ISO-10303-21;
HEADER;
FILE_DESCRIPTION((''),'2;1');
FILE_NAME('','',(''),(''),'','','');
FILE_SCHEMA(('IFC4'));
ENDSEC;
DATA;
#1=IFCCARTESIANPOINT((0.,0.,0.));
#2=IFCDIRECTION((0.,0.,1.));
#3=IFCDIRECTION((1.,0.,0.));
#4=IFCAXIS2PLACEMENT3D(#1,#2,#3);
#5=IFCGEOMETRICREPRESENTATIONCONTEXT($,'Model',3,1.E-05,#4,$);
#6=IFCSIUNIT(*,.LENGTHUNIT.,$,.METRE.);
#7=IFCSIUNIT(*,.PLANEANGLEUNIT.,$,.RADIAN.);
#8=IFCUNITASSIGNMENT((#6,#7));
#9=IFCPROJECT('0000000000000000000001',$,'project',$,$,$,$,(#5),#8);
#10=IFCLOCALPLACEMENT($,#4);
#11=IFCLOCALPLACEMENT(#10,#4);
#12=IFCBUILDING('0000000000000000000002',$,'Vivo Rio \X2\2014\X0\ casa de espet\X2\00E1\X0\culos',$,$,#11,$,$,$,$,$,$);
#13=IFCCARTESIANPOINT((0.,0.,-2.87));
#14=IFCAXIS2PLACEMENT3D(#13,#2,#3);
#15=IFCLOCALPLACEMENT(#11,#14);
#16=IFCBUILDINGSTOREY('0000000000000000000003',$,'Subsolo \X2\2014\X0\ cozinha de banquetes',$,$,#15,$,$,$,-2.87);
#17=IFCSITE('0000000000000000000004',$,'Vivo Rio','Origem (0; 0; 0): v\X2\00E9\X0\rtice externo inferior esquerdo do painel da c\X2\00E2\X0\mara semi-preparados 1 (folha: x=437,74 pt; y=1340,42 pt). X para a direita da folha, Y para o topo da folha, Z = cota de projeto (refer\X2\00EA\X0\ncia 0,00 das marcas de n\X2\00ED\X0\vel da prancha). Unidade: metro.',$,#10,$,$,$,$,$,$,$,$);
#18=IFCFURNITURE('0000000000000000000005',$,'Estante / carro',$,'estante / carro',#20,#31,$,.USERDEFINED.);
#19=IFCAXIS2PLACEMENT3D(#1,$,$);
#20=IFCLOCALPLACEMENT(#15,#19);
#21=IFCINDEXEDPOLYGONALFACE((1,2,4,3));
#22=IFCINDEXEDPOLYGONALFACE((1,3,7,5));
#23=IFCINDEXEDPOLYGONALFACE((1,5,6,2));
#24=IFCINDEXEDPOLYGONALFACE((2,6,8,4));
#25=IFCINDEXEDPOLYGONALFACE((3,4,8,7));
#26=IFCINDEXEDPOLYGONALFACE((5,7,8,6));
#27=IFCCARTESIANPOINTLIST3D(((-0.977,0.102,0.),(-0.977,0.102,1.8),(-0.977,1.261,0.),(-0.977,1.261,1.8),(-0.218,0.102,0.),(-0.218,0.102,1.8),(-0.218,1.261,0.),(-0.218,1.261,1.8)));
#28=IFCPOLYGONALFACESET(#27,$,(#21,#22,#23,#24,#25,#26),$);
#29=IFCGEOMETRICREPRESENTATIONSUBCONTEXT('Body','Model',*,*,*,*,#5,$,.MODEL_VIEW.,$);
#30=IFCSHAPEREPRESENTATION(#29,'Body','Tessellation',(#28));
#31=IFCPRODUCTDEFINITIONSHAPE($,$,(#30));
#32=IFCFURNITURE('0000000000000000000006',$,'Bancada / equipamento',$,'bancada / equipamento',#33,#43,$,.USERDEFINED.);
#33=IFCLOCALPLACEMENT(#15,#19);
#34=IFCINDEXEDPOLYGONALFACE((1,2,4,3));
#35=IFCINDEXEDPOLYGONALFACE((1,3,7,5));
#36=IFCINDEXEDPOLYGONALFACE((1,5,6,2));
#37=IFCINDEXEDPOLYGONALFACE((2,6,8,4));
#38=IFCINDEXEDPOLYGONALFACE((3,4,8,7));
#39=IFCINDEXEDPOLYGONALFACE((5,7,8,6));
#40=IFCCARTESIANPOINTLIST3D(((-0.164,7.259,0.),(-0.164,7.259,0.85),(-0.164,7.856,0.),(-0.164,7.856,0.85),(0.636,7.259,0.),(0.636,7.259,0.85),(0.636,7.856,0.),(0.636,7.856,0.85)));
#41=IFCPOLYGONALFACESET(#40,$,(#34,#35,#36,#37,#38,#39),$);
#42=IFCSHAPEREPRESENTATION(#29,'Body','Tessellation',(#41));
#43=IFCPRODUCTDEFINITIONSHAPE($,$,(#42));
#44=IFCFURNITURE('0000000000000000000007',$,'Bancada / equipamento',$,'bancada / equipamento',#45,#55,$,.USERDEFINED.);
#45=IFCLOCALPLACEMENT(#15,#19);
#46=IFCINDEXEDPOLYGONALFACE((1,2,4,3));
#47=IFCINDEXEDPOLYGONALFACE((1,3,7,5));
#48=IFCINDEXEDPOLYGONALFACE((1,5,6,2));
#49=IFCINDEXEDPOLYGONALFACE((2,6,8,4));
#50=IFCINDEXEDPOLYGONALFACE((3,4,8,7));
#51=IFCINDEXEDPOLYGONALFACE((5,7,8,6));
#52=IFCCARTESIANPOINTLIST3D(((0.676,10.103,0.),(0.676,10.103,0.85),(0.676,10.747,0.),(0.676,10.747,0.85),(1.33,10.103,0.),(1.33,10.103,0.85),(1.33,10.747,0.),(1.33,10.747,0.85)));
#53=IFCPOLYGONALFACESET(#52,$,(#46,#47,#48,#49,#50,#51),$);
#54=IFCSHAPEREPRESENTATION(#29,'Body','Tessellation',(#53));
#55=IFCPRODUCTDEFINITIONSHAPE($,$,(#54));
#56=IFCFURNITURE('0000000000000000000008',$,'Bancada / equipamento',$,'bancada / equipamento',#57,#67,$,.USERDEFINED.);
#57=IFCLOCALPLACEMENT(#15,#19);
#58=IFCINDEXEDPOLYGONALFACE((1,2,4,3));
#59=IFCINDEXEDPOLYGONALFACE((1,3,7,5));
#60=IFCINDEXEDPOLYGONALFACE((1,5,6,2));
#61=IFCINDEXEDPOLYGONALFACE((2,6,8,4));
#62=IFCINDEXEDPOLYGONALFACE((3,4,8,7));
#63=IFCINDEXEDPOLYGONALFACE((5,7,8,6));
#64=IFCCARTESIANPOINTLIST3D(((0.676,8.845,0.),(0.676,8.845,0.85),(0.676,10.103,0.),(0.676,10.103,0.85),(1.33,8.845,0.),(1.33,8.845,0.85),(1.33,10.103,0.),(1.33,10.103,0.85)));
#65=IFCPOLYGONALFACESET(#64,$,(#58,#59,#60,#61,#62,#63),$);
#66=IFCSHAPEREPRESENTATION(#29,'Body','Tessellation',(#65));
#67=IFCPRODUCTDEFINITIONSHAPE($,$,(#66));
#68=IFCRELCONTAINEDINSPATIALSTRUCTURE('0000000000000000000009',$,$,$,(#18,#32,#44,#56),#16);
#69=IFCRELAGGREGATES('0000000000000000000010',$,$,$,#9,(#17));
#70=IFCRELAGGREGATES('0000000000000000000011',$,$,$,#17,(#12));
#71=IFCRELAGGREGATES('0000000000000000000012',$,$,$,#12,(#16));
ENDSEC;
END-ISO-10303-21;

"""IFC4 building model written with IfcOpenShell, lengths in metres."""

from ifc_helpers import new_model, si_unit, frame, origin_with_axes, origin_2d, place, context, subcontext, project, spatial, rectangle, extrude, element, save


model = new_model("IFC4")

# Units and contexts
model_context = context("Model", 3, precision=1e-05, world=origin_with_axes())
body_context = subcontext(model_context, "Body", "Model", "MODEL_VIEW")
ifc_project = project(units=[si_unit("LENGTHUNIT", "METRE"), si_unit("PLANEANGLEUNIT", "RADIAN")], contexts=[model_context])

# Site, building, storey
site_placement = place(None, origin_with_axes())
site = spatial("IfcSite", under=ifc_project, at=site_placement, Name="Vivo Rio", Description="Origem (0; 0; 0): vértice externo inferior esquerdo do painel da câmara semi-preparados 1 (folha: x=437,74 pt; y=1340,42 pt). X para a direita da folha, Y para o topo da folha, Z = cota de projeto (referência 0,00 das marcas de nível da prancha). Unidade: metro.")
building_placement = place(site_placement, origin_with_axes())
building = spatial("IfcBuilding", under=site, at=building_placement, Name="Vivo Rio — casa de espetáculos")
storey_placement = place(building_placement, frame((0.0, 0.0, -2.87), z_axis=(0.0, 0.0, 1.0), x_axis=(1.0, 0.0, 0.0)))
storey = spatial("IfcBuildingStorey", under=building, at=storey_placement, Name="Subsolo — cozinha de banquetes", Elevation=-2.87)

# Furniture
furniture_1_placement = place(storey_placement, origin_with_axes())
element("IfcFurniture", 1, at=furniture_1_placement, inside=storey, Name="Estante / carro", ObjectType="estante / carro", PredefinedType="USERDEFINED", context=body_context, shape_type="SweptSolid", body=[
    extrude(rectangle(XDim=0.759, YDim=1.159, at=origin_2d()), frame((-0.5975, 0.6815, 0.0), z_axis=(0.0, 0.0, 1.0), x_axis=(1.0, 0.0, 0.0)), (0.0, 0.0, 1.0), 1.8),
])
furniture_2_placement = place(storey_placement, origin_with_axes())
element("IfcFurniture", 2, at=furniture_2_placement, inside=storey, Name="Bancada / equipamento", ObjectType="bancada / equipamento", PredefinedType="USERDEFINED", context=body_context, shape_type="SweptSolid", body=[
    extrude(rectangle(XDim=0.8, YDim=0.597, at=origin_2d()), frame((0.236, 7.5575, 0.0), z_axis=(0.0, 0.0, 1.0), x_axis=(1.0, 0.0, 0.0)), (0.0, 0.0, 1.0), 0.85),
])
furniture_3_placement = place(storey_placement, origin_with_axes())
element("IfcFurniture", 3, at=furniture_3_placement, inside=storey, Name="Bancada / equipamento", ObjectType="bancada / equipamento", PredefinedType="USERDEFINED", context=body_context, shape_type="SweptSolid", body=[
    extrude(rectangle(XDim=0.654, YDim=0.644, at=origin_2d()), frame((1.003, 10.425, 0.0), z_axis=(0.0, 0.0, 1.0), x_axis=(1.0, 0.0, 0.0)), (0.0, 0.0, 1.0), 0.85),
])
furniture_4_placement = place(storey_placement, origin_with_axes())
element("IfcFurniture", 4, at=furniture_4_placement, inside=storey, Name="Bancada / equipamento", ObjectType="bancada / equipamento", PredefinedType="USERDEFINED", context=body_context, shape_type="SweptSolid", body=[
    extrude(rectangle(XDim=0.654, YDim=1.258, at=origin_2d()), frame((1.003, 9.474, 0.0), z_axis=(0.0, 0.0, 1.0), x_axis=(1.0, 0.0, 0.0)), (0.0, 0.0, 1.0), 0.85),
])

save(model, "model.ifc")
